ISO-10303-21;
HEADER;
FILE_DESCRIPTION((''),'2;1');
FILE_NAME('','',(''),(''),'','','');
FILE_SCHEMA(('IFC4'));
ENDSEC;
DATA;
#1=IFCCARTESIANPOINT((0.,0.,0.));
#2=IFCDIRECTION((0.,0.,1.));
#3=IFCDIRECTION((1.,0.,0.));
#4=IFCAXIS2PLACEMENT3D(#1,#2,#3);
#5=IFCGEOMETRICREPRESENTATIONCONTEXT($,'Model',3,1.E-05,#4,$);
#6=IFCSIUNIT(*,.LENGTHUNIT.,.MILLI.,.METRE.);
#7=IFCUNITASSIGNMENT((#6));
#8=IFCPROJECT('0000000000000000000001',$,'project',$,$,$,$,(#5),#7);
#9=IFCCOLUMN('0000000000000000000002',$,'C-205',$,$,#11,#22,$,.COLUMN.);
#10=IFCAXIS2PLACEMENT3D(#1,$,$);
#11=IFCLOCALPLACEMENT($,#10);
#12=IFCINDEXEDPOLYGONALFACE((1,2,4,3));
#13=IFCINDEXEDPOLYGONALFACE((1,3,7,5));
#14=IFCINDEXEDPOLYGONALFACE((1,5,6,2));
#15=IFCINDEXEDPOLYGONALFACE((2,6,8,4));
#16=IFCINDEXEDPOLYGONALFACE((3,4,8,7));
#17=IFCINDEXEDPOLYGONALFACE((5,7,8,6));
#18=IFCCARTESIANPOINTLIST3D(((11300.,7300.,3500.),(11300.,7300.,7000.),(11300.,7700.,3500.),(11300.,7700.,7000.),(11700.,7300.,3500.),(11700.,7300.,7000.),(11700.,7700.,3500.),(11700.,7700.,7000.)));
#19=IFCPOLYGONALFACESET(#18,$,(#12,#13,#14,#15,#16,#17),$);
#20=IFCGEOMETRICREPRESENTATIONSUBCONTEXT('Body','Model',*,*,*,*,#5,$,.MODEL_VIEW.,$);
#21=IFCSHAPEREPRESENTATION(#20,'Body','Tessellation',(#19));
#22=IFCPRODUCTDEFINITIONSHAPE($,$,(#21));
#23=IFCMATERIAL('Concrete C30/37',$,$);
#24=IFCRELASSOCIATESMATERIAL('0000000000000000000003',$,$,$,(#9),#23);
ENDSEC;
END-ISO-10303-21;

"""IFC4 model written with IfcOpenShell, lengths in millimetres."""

from ifc_helpers import new_model, si_unit, frame, origin_with_axes, place, context, subcontext, project, indexed_curve, outline, extrude, material, element, save


model = new_model("IFC4")

# Units and contexts
model_context = context("Model", 3, precision=1e-05, world=origin_with_axes())
body_context = subcontext(model_context, "Body", "Model", "MODEL_VIEW")
ifc_project = project(units=[si_unit("LENGTHUNIT", "METRE", prefix="MILLI")], contexts=[model_context])

# Column
ifc_material = material(Name="Concrete C30/37")
column_placement = place(None, frame((11300.0, 7300.0, 3500.0), z_axis=(0.0, 0.0, 1.0), x_axis=(1.0, 0.0, 0.0)))
element("IfcColumn", 1, at=column_placement, material=ifc_material, Name="C-205", PredefinedType="COLUMN", context=body_context, shape_type="SweptSolid", body=[
    extrude(outline(indexed_curve([(0.0, 0.0), (0.0, 400.0), (400.0, 400.0), (400.0, 0.0), (0.0, 0.0)], self_intersect=False)), origin_with_axes(), (0.0, 0.0, 1.0), 3500.0),
])

save(model, "model.ifc")
